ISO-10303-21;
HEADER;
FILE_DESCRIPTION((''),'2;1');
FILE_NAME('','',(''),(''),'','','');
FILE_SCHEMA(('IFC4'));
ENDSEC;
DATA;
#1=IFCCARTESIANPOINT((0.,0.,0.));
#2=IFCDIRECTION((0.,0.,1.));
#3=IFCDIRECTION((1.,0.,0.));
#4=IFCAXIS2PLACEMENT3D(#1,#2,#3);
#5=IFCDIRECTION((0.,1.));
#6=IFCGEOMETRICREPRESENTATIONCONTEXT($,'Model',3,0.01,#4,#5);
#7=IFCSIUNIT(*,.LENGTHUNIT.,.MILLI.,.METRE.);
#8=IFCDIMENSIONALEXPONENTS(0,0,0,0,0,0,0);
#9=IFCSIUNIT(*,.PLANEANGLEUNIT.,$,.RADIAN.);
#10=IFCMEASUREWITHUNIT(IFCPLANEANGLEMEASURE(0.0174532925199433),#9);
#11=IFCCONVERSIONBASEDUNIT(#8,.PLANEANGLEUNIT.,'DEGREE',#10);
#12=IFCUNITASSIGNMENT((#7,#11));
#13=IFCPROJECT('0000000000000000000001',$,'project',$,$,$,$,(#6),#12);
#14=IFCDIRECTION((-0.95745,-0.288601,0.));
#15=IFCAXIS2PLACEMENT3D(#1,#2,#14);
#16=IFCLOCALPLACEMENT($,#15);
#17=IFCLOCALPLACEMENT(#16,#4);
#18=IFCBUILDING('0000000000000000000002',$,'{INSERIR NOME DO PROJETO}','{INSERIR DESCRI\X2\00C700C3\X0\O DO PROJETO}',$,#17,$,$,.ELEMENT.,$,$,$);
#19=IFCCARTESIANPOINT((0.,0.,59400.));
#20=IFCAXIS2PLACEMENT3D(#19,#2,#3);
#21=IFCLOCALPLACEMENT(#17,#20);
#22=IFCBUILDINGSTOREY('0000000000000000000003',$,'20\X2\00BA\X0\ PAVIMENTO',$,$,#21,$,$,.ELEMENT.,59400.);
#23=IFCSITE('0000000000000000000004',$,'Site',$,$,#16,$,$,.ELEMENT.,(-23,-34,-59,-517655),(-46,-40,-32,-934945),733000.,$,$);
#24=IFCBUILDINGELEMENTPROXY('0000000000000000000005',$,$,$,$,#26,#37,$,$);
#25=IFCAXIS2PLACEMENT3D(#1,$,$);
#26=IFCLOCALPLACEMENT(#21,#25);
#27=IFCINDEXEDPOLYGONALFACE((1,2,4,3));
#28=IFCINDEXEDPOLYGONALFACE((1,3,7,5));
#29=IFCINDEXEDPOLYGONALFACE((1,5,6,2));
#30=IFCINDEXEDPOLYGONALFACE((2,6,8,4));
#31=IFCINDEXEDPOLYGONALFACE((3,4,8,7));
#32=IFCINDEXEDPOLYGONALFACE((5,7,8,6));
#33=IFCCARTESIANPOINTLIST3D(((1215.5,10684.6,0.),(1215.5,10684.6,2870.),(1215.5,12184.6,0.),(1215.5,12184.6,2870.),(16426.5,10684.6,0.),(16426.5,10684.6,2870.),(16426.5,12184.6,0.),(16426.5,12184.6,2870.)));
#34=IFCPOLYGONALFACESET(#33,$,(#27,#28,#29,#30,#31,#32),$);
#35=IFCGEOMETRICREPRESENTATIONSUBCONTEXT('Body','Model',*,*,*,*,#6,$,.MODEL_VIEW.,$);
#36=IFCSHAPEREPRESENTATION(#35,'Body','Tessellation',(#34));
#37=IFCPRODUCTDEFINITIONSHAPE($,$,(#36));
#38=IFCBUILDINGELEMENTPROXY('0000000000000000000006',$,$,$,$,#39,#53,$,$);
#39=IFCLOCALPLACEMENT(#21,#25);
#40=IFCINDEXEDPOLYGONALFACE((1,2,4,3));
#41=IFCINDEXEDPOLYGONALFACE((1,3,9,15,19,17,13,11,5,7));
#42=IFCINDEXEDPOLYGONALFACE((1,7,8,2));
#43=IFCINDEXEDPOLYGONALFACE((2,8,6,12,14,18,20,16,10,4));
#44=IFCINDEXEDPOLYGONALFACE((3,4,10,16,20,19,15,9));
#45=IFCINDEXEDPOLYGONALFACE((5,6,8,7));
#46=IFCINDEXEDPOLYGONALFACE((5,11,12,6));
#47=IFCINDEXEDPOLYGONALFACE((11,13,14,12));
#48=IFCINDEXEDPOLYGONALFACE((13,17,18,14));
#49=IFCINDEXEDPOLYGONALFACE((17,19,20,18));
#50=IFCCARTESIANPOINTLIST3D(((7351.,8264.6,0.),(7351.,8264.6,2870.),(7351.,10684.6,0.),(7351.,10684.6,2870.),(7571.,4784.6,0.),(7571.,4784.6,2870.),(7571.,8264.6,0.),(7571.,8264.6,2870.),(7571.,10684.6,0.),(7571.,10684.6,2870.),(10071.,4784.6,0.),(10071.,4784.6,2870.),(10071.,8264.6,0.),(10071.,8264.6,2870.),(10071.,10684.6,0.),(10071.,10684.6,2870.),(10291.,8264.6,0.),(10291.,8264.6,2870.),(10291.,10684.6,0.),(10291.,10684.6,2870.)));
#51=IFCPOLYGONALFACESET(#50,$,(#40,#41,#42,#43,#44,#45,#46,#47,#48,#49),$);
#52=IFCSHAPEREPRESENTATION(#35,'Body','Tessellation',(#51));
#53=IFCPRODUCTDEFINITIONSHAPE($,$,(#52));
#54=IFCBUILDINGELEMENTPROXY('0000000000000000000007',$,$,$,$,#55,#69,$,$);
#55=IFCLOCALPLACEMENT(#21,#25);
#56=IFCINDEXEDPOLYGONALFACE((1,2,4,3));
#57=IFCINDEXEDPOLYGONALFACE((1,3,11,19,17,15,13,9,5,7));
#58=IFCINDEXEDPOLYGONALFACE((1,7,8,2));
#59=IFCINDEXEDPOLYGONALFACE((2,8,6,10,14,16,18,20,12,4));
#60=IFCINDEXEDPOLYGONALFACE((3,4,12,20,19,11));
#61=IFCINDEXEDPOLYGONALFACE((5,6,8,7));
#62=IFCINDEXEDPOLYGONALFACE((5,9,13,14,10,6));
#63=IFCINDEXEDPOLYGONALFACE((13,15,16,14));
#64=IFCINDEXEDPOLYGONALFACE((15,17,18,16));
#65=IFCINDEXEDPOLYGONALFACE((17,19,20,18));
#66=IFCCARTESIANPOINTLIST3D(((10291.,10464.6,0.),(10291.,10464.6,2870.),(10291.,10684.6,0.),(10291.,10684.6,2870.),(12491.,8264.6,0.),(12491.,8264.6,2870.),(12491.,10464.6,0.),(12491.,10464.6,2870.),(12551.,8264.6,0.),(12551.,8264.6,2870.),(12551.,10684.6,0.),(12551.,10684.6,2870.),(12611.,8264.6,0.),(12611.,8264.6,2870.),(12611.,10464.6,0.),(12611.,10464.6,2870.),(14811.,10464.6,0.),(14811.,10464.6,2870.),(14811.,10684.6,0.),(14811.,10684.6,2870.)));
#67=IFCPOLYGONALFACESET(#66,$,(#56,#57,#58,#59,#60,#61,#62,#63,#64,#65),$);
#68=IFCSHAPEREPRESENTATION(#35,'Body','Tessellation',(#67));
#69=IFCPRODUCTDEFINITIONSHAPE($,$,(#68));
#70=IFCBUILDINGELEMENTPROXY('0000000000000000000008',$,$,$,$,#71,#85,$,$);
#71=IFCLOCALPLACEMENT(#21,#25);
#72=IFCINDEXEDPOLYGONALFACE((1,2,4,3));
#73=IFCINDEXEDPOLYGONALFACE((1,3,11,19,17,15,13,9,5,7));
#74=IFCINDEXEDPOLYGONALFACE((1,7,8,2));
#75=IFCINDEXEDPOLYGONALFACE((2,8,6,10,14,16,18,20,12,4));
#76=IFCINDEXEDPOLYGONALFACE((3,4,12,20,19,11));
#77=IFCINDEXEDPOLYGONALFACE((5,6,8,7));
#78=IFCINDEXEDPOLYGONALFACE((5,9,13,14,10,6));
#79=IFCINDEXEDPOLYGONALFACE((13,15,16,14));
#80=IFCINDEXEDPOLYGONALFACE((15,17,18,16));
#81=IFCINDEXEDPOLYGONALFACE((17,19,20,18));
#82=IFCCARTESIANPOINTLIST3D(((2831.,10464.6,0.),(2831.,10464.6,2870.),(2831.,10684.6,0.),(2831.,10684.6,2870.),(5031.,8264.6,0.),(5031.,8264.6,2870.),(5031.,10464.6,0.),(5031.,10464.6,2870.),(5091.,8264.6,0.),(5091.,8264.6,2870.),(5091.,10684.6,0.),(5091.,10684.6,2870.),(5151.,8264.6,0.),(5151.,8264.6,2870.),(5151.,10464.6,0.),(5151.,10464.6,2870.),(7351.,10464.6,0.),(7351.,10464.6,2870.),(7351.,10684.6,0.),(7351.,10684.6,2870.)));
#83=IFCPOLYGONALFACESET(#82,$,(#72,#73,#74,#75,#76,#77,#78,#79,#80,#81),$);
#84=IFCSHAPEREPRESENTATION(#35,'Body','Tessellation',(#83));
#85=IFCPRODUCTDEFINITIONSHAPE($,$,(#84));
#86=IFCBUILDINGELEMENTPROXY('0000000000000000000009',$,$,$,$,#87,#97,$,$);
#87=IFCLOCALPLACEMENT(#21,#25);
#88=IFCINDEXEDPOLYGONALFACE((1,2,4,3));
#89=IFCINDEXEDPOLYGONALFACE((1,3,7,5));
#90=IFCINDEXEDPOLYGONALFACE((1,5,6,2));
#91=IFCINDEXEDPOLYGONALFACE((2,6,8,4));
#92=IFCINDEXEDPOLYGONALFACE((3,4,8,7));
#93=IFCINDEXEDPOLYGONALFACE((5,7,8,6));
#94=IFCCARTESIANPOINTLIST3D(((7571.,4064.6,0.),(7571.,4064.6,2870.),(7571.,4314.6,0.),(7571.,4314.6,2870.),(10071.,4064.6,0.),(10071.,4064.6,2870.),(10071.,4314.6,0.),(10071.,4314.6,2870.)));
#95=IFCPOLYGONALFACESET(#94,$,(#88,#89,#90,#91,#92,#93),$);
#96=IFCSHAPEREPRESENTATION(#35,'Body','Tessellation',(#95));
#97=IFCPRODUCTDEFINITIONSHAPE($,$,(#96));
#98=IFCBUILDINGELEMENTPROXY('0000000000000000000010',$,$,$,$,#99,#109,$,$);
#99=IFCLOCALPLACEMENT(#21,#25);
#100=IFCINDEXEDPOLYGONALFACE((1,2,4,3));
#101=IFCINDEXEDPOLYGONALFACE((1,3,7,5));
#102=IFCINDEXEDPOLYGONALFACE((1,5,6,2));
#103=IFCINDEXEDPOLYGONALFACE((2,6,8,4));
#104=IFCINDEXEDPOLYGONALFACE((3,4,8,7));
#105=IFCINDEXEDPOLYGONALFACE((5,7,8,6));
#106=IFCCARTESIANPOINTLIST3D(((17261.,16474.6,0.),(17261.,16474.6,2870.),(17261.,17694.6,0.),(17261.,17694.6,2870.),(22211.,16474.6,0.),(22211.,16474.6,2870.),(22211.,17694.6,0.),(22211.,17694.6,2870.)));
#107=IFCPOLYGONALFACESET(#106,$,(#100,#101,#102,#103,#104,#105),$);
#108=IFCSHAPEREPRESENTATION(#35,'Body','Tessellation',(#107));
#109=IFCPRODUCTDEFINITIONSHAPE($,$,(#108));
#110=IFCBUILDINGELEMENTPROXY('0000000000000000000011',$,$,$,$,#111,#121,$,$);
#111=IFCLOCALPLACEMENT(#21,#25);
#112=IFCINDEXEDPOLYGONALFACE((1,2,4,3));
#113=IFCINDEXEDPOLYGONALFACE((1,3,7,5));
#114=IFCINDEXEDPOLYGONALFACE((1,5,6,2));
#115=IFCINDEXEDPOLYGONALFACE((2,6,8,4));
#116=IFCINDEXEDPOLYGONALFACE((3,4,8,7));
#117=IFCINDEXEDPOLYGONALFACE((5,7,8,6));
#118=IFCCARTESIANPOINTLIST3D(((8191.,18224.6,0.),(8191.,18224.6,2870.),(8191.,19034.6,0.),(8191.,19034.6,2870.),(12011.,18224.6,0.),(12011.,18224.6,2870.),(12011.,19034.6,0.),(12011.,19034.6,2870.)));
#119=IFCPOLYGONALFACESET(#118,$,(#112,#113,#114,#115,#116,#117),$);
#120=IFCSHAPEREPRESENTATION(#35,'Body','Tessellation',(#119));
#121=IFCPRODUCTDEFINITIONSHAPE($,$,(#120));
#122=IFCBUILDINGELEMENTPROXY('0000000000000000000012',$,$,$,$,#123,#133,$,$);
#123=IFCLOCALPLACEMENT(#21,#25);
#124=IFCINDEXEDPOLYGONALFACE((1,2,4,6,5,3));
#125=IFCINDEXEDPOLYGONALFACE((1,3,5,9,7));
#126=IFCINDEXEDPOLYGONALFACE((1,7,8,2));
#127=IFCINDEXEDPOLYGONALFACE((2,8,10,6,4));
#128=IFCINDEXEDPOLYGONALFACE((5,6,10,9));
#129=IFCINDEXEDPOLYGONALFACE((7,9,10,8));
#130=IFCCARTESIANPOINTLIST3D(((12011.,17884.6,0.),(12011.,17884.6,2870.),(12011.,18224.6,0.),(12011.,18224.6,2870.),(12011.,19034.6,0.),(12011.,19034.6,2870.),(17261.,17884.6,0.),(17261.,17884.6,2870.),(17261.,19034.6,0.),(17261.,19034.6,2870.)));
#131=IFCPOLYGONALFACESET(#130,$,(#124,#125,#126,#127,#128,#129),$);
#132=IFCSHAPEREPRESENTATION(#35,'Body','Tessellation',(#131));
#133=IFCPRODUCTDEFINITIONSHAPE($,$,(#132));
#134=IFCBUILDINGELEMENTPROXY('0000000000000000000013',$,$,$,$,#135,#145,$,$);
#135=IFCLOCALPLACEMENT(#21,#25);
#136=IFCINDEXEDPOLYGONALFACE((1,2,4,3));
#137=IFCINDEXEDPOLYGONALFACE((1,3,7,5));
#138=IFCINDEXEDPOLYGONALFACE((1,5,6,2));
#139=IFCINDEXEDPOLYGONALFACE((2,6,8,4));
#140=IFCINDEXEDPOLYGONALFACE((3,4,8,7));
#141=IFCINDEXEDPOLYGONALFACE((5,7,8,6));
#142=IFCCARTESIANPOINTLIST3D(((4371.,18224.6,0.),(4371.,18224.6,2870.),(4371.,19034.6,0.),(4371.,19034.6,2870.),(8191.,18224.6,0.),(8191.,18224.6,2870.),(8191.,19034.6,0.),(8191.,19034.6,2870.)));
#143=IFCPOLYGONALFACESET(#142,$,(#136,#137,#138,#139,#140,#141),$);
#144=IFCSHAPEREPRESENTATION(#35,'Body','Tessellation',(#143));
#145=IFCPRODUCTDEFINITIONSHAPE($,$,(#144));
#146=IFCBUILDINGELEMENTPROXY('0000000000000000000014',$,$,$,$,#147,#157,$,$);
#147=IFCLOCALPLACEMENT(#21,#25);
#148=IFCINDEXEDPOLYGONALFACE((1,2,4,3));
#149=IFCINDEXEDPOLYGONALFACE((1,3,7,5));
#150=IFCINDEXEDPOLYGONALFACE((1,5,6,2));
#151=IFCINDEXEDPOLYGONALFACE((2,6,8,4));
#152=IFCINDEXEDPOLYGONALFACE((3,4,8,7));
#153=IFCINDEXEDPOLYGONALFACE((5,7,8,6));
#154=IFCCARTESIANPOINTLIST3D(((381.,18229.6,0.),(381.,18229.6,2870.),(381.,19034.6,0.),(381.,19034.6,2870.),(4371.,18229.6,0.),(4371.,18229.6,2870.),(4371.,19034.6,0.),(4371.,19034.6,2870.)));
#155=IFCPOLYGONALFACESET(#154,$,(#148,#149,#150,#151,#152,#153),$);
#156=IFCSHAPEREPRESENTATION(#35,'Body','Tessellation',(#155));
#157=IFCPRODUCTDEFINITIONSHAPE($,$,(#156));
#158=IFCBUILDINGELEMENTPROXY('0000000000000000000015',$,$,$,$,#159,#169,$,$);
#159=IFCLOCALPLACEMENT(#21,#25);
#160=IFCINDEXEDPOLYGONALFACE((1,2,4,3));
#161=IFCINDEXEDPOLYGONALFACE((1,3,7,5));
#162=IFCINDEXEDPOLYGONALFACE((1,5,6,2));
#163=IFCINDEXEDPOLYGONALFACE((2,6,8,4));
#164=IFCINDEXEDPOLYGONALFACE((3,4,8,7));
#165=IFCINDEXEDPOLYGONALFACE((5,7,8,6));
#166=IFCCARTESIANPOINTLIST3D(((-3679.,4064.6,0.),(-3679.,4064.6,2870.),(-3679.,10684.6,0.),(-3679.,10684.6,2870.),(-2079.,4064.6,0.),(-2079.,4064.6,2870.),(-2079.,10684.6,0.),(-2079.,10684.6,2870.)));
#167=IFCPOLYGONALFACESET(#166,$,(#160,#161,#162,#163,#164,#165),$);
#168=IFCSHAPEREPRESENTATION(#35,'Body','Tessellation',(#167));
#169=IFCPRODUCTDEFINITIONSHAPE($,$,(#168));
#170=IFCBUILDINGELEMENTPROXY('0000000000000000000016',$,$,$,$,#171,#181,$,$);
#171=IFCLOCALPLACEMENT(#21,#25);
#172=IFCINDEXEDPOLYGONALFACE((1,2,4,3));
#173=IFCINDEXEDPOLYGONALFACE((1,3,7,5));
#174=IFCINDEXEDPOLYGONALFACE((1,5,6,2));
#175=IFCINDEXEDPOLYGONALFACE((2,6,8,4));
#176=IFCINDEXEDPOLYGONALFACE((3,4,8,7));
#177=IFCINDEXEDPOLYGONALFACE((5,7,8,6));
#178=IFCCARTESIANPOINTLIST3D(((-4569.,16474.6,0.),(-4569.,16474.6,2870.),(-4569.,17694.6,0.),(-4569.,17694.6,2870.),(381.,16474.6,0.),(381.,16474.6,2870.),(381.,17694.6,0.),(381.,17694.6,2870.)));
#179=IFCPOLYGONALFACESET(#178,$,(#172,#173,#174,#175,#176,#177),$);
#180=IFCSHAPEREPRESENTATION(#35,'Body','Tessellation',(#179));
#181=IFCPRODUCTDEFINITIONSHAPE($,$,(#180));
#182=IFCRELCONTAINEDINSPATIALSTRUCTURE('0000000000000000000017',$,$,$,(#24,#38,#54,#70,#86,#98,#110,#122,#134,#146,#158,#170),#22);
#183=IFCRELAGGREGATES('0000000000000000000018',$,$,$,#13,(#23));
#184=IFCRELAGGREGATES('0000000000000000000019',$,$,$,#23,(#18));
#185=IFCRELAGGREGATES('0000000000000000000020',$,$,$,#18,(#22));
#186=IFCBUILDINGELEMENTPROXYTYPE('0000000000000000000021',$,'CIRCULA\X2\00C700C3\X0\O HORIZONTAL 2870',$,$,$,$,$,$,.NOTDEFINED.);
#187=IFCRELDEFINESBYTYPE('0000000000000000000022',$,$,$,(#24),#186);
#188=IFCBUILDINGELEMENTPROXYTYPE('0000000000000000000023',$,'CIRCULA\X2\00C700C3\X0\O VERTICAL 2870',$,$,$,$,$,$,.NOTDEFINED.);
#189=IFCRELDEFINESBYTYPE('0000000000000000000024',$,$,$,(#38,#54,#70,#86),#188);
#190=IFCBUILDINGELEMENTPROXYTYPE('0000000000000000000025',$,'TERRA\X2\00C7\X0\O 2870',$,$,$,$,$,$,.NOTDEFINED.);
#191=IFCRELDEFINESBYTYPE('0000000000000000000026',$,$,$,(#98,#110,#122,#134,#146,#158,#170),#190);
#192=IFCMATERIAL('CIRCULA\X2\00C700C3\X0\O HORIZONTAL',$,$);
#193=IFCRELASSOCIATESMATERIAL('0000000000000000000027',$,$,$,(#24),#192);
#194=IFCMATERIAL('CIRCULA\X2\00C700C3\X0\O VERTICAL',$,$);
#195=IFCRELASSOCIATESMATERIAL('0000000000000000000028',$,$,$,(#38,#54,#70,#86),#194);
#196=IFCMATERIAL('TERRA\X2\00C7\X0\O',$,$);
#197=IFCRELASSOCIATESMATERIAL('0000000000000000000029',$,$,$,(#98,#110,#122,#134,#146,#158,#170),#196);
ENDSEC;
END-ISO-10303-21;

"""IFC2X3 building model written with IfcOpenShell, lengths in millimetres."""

from ifc_helpers import new_model, entity, si_unit, converted_unit, direction, frame, origin_with_axes, place, context, subcontext, project, spatial, polyline, outline, extrude, material, type_object, element, save


model = new_model("IFC2X3")

# Units and contexts
model_context = context("Model", 3, precision=0.01, world=origin_with_axes(), true_north=direction((0.0, 1.0)))
body_context = subcontext(model_context, "Body", "Model", "MODEL_VIEW")
ifc_project = project(units=[si_unit("LENGTHUNIT", "METRE", prefix="MILLI"), converted_unit("PLANEANGLEUNIT", "DEGREE", entity("IfcPlaneAngleMeasure", 0.0174532925199433), si_unit("PLANEANGLEUNIT", "RADIAN"), dimensions=[0, 0, 0, 0, 0, 0, 0])], contexts=[model_context])

# Site, building, storey
site_placement = place(None, frame((0.0, 0.0, 0.0), z_axis=(0.0, 0.0, 1.0), x_axis=(-0.95745, -0.288601, 0.0)))
site = spatial("IfcSite", under=ifc_project, at=site_placement, Name="Site", CompositionType="ELEMENT", RefLatitude=(-23, -34, -59, -517655), RefLongitude=(-46, -40, -32, -934945), RefElevation=733000.0)
building_placement = place(site_placement, origin_with_axes())
building = spatial("IfcBuilding", under=site, at=building_placement, Name="{INSERIR NOME DO PROJETO}", Description="{INSERIR DESCRIÇÃO DO PROJETO}", CompositionType="ELEMENT")
storey_placement = place(building_placement, frame((0.0, 0.0, 59400.0), z_axis=(0.0, 0.0, 1.0), x_axis=(1.0, 0.0, 0.0)))
storey = spatial("IfcBuildingStorey", under=building, at=storey_placement, Name="20º PAVIMENTO", CompositionType="ELEMENT", Elevation=59400.0)

# Building element proxies
ifc_material_1 = material(Name="CIRCULAÇÃO HORIZONTAL")
building_element_proxy_type_1 = type_object("IfcBuildingElementProxyType", Name="CIRCULAÇÃO HORIZONTAL 2870", PredefinedType="NOTDEFINED")
proxy_1_placement = place(storey_placement, frame((1215.5, 10684.6, 0.0), z_axis=(0.0, 0.0, 1.0), x_axis=(1.0, 0.0, 0.0)))
element("IfcBuildingElementProxy", 1, at=proxy_1_placement, inside=storey, type_object=building_element_proxy_type_1, material=ifc_material_1, context=body_context, shape_type="SweptSolid", body=[
    extrude(outline(polyline([(0.0, 0.0), (15211.0, 0.0), (15211.0, 1500.0), (0.0, 1500.0), (0.0, 0.0)])), origin_with_axes(), (0.0, 0.0, 1.0), 2870.0),
])
ifc_material_2 = material(Name="CIRCULAÇÃO VERTICAL")
building_element_proxy_type_2 = type_object("IfcBuildingElementProxyType", Name="CIRCULAÇÃO VERTICAL 2870", PredefinedType="NOTDEFINED")
proxy_2_placement = place(storey_placement, frame((7351.0, 10684.6, 0.0), z_axis=(0.0, 0.0, 1.0), x_axis=(1.0, 0.0, 0.0)))
element("IfcBuildingElementProxy", 2, at=proxy_2_placement, inside=storey, type_object=building_element_proxy_type_2, material=ifc_material_2, context=body_context, shape_type="SweptSolid", body=[
    extrude(outline(polyline([(0.0, 0.0), (0.0, -2420.0), (220.0, -2420.0), (220.0, -5900.0), (2720.0, -5900.0), (2720.0, -2420.0), (2940.0, -2420.0), (2940.0, 0.0), (2720.0, 0.0), (220.0, 0.0), (0.0, 0.0)])), origin_with_axes(), (0.0, 0.0, 1.0), 2870.0),
])
proxy_3_placement = place(storey_placement, frame((10291.0, 10684.6, 0.0), z_axis=(0.0, 0.0, 1.0), x_axis=(1.0, 0.0, 0.0)))
element("IfcBuildingElementProxy", 3, at=proxy_3_placement, inside=storey, type_object=building_element_proxy_type_2, material=ifc_material_2, context=body_context, shape_type="SweptSolid", body=[
    extrude(outline(polyline([(0.0, 0.0), (0.0, -220.0), (2200.0, -220.0), (2200.0, -2420.0), (2260.0, -2420.0), (2320.0, -2420.0), (2320.0, -220.0), (4520.0, -220.0), (4520.0, 0.0), (2260.0, 0.0), (0.0, 0.0)])), origin_with_axes(), (0.0, 0.0, 1.0), 2870.0),
])
proxy_4_placement = place(storey_placement, frame((5091.0, 10684.6, 0.0), z_axis=(0.0, 0.0, 1.0), x_axis=(1.0, 0.0, 0.0)))
element("IfcBuildingElementProxy", 4, at=proxy_4_placement, inside=storey, type_object=building_element_proxy_type_2, material=ifc_material_2, context=body_context, shape_type="SweptSolid", body=[
    extrude(outline(polyline([(0.0, 0.0), (-2260.0, 0.0), (-2260.0, -220.0), (-60.0, -220.0), (-60.0, -2420.0), (0.0, -2420.0), (60.0, -2420.0), (60.0, -220.0), (2260.0, -220.0), (2260.0, 0.0), (0.0, 0.0)])), origin_with_axes(), (0.0, 0.0, 1.0), 2870.0),
])
proxy_5_placement = place(storey_placement, frame((7571.0, 4064.6, 0.0), z_axis=(0.0, 0.0, 1.0), x_axis=(1.0, 0.0, 0.0)))
element("IfcBuildingElementProxy", 5, at=proxy_5_placement, inside=storey, type_object=building_element_proxy_type_2, material=ifc_material_2, context=body_context, shape_type="SweptSolid", body=[
    extrude(outline(polyline([(0.0, 0.0), (2500.0, 0.0), (2500.0, 250.0), (0.0, 250.0), (0.0, 0.0)])), origin_with_axes(), (0.0, 0.0, 1.0), 2870.0),
])
ifc_material_3 = material(Name="TERRAÇO")
building_element_proxy_type_3 = type_object("IfcBuildingElementProxyType", Name="TERRAÇO 2870", PredefinedType="NOTDEFINED")
proxy_6_placement = place(storey_placement, frame((17261.0, 16474.6, 0.0), z_axis=(0.0, 0.0, 1.0), x_axis=(1.0, 0.0, 0.0)))
element("IfcBuildingElementProxy", 6, at=proxy_6_placement, inside=storey, type_object=building_element_proxy_type_3, material=ifc_material_3, context=body_context, shape_type="SweptSolid", body=[
    extrude(outline(polyline([(0.0, 0.0), (4950.0, 0.0), (4950.0, 1220.0), (0.0, 1220.0), (0.0, 0.0)])), origin_with_axes(), (0.0, 0.0, 1.0), 2870.0),
])
proxy_7_placement = place(storey_placement, frame((8191.0, 18224.6, 0.0), z_axis=(0.0, 0.0, 1.0), x_axis=(1.0, 0.0, 0.0)))
element("IfcBuildingElementProxy", 7, at=proxy_7_placement, inside=storey, type_object=building_element_proxy_type_3, material=ifc_material_3, context=body_context, shape_type="SweptSolid", body=[
    extrude(outline(polyline([(0.0, 0.0), (3820.0, 0.0), (3820.0, 810.0), (0.0, 810.0), (0.0, 0.0)])), origin_with_axes(), (0.0, 0.0, 1.0), 2870.0),
])
proxy_8_placement = place(storey_placement, frame((12011.0, 19034.6, 0.0), z_axis=(0.0, 0.0, 1.0), x_axis=(1.0, 0.0, 0.0)))
element("IfcBuildingElementProxy", 8, at=proxy_8_placement, inside=storey, type_object=building_element_proxy_type_3, material=ifc_material_3, context=body_context, shape_type="SweptSolid", body=[
    extrude(outline(polyline([(0.0, 0.0), (0.0, -810.0), (0.0, -1150.0), (5250.0, -1150.0), (5250.0, 0.0), (0.0, 0.0)])), origin_with_axes(), (0.0, 0.0, 1.0), 2870.0),
])
proxy_9_placement = place(storey_placement, frame((4371.0, 18224.6, 0.0), z_axis=(0.0, 0.0, 1.0), x_axis=(1.0, 0.0, 0.0)))
element("IfcBuildingElementProxy", 9, at=proxy_9_placement, inside=storey, type_object=building_element_proxy_type_3, material=ifc_material_3, context=body_context, shape_type="SweptSolid", body=[
    extrude(outline(polyline([(0.0, 0.0), (3820.0, 0.0), (3820.0, 810.0), (0.0, 810.0), (0.0, 0.0)])), origin_with_axes(), (0.0, 0.0, 1.0), 2870.0),
])
proxy_10_placement = place(storey_placement, frame((381.0, 19034.6, 0.0), z_axis=(0.0, 0.0, 1.0), x_axis=(1.0, 0.0, 0.0)))
element("IfcBuildingElementProxy", 10, at=proxy_10_placement, inside=storey, type_object=building_element_proxy_type_3, material=ifc_material_3, context=body_context, shape_type="SweptSolid", body=[
    extrude(outline(polyline([(0.0, 0.0), (0.0, -805.0), (3990.0, -805.0), (3990.0, 0.0), (0.0, 0.0)])), origin_with_axes(), (0.0, 0.0, 1.0), 2870.0),
])
proxy_11_placement = place(storey_placement, frame((-3679.0, 4064.6, 0.0), z_axis=(0.0, 0.0, 1.0), x_axis=(1.0, 0.0, 0.0)))
element("IfcBuildingElementProxy", 11, at=proxy_11_placement, inside=storey, type_object=building_element_proxy_type_3, material=ifc_material_3, context=body_context, shape_type="SweptSolid", body=[
    extrude(outline(polyline([(0.0, 0.0), (1600.0, 0.0), (1600.0, 6620.0), (0.0, 6620.0), (0.0, 0.0)])), origin_with_axes(), (0.0, 0.0, 1.0), 2870.0),
])
proxy_12_placement = place(storey_placement, frame((381.0, 17694.6, 0.0), z_axis=(0.0, 0.0, 1.0), x_axis=(1.0, 0.0, 0.0)))
element("IfcBuildingElementProxy", 12, at=proxy_12_placement, inside=storey, type_object=building_element_proxy_type_3, material=ifc_material_3, context=body_context, shape_type="SweptSolid", body=[
    extrude(outline(polyline([(0.0, 0.0), (-4950.0, 0.0), (-4950.0, -1220.0), (0.0, -1220.0), (0.0, 0.0)])), origin_with_axes(), (0.0, 0.0, 1.0), 2870.0),
])

save(model, "model.ifc")
